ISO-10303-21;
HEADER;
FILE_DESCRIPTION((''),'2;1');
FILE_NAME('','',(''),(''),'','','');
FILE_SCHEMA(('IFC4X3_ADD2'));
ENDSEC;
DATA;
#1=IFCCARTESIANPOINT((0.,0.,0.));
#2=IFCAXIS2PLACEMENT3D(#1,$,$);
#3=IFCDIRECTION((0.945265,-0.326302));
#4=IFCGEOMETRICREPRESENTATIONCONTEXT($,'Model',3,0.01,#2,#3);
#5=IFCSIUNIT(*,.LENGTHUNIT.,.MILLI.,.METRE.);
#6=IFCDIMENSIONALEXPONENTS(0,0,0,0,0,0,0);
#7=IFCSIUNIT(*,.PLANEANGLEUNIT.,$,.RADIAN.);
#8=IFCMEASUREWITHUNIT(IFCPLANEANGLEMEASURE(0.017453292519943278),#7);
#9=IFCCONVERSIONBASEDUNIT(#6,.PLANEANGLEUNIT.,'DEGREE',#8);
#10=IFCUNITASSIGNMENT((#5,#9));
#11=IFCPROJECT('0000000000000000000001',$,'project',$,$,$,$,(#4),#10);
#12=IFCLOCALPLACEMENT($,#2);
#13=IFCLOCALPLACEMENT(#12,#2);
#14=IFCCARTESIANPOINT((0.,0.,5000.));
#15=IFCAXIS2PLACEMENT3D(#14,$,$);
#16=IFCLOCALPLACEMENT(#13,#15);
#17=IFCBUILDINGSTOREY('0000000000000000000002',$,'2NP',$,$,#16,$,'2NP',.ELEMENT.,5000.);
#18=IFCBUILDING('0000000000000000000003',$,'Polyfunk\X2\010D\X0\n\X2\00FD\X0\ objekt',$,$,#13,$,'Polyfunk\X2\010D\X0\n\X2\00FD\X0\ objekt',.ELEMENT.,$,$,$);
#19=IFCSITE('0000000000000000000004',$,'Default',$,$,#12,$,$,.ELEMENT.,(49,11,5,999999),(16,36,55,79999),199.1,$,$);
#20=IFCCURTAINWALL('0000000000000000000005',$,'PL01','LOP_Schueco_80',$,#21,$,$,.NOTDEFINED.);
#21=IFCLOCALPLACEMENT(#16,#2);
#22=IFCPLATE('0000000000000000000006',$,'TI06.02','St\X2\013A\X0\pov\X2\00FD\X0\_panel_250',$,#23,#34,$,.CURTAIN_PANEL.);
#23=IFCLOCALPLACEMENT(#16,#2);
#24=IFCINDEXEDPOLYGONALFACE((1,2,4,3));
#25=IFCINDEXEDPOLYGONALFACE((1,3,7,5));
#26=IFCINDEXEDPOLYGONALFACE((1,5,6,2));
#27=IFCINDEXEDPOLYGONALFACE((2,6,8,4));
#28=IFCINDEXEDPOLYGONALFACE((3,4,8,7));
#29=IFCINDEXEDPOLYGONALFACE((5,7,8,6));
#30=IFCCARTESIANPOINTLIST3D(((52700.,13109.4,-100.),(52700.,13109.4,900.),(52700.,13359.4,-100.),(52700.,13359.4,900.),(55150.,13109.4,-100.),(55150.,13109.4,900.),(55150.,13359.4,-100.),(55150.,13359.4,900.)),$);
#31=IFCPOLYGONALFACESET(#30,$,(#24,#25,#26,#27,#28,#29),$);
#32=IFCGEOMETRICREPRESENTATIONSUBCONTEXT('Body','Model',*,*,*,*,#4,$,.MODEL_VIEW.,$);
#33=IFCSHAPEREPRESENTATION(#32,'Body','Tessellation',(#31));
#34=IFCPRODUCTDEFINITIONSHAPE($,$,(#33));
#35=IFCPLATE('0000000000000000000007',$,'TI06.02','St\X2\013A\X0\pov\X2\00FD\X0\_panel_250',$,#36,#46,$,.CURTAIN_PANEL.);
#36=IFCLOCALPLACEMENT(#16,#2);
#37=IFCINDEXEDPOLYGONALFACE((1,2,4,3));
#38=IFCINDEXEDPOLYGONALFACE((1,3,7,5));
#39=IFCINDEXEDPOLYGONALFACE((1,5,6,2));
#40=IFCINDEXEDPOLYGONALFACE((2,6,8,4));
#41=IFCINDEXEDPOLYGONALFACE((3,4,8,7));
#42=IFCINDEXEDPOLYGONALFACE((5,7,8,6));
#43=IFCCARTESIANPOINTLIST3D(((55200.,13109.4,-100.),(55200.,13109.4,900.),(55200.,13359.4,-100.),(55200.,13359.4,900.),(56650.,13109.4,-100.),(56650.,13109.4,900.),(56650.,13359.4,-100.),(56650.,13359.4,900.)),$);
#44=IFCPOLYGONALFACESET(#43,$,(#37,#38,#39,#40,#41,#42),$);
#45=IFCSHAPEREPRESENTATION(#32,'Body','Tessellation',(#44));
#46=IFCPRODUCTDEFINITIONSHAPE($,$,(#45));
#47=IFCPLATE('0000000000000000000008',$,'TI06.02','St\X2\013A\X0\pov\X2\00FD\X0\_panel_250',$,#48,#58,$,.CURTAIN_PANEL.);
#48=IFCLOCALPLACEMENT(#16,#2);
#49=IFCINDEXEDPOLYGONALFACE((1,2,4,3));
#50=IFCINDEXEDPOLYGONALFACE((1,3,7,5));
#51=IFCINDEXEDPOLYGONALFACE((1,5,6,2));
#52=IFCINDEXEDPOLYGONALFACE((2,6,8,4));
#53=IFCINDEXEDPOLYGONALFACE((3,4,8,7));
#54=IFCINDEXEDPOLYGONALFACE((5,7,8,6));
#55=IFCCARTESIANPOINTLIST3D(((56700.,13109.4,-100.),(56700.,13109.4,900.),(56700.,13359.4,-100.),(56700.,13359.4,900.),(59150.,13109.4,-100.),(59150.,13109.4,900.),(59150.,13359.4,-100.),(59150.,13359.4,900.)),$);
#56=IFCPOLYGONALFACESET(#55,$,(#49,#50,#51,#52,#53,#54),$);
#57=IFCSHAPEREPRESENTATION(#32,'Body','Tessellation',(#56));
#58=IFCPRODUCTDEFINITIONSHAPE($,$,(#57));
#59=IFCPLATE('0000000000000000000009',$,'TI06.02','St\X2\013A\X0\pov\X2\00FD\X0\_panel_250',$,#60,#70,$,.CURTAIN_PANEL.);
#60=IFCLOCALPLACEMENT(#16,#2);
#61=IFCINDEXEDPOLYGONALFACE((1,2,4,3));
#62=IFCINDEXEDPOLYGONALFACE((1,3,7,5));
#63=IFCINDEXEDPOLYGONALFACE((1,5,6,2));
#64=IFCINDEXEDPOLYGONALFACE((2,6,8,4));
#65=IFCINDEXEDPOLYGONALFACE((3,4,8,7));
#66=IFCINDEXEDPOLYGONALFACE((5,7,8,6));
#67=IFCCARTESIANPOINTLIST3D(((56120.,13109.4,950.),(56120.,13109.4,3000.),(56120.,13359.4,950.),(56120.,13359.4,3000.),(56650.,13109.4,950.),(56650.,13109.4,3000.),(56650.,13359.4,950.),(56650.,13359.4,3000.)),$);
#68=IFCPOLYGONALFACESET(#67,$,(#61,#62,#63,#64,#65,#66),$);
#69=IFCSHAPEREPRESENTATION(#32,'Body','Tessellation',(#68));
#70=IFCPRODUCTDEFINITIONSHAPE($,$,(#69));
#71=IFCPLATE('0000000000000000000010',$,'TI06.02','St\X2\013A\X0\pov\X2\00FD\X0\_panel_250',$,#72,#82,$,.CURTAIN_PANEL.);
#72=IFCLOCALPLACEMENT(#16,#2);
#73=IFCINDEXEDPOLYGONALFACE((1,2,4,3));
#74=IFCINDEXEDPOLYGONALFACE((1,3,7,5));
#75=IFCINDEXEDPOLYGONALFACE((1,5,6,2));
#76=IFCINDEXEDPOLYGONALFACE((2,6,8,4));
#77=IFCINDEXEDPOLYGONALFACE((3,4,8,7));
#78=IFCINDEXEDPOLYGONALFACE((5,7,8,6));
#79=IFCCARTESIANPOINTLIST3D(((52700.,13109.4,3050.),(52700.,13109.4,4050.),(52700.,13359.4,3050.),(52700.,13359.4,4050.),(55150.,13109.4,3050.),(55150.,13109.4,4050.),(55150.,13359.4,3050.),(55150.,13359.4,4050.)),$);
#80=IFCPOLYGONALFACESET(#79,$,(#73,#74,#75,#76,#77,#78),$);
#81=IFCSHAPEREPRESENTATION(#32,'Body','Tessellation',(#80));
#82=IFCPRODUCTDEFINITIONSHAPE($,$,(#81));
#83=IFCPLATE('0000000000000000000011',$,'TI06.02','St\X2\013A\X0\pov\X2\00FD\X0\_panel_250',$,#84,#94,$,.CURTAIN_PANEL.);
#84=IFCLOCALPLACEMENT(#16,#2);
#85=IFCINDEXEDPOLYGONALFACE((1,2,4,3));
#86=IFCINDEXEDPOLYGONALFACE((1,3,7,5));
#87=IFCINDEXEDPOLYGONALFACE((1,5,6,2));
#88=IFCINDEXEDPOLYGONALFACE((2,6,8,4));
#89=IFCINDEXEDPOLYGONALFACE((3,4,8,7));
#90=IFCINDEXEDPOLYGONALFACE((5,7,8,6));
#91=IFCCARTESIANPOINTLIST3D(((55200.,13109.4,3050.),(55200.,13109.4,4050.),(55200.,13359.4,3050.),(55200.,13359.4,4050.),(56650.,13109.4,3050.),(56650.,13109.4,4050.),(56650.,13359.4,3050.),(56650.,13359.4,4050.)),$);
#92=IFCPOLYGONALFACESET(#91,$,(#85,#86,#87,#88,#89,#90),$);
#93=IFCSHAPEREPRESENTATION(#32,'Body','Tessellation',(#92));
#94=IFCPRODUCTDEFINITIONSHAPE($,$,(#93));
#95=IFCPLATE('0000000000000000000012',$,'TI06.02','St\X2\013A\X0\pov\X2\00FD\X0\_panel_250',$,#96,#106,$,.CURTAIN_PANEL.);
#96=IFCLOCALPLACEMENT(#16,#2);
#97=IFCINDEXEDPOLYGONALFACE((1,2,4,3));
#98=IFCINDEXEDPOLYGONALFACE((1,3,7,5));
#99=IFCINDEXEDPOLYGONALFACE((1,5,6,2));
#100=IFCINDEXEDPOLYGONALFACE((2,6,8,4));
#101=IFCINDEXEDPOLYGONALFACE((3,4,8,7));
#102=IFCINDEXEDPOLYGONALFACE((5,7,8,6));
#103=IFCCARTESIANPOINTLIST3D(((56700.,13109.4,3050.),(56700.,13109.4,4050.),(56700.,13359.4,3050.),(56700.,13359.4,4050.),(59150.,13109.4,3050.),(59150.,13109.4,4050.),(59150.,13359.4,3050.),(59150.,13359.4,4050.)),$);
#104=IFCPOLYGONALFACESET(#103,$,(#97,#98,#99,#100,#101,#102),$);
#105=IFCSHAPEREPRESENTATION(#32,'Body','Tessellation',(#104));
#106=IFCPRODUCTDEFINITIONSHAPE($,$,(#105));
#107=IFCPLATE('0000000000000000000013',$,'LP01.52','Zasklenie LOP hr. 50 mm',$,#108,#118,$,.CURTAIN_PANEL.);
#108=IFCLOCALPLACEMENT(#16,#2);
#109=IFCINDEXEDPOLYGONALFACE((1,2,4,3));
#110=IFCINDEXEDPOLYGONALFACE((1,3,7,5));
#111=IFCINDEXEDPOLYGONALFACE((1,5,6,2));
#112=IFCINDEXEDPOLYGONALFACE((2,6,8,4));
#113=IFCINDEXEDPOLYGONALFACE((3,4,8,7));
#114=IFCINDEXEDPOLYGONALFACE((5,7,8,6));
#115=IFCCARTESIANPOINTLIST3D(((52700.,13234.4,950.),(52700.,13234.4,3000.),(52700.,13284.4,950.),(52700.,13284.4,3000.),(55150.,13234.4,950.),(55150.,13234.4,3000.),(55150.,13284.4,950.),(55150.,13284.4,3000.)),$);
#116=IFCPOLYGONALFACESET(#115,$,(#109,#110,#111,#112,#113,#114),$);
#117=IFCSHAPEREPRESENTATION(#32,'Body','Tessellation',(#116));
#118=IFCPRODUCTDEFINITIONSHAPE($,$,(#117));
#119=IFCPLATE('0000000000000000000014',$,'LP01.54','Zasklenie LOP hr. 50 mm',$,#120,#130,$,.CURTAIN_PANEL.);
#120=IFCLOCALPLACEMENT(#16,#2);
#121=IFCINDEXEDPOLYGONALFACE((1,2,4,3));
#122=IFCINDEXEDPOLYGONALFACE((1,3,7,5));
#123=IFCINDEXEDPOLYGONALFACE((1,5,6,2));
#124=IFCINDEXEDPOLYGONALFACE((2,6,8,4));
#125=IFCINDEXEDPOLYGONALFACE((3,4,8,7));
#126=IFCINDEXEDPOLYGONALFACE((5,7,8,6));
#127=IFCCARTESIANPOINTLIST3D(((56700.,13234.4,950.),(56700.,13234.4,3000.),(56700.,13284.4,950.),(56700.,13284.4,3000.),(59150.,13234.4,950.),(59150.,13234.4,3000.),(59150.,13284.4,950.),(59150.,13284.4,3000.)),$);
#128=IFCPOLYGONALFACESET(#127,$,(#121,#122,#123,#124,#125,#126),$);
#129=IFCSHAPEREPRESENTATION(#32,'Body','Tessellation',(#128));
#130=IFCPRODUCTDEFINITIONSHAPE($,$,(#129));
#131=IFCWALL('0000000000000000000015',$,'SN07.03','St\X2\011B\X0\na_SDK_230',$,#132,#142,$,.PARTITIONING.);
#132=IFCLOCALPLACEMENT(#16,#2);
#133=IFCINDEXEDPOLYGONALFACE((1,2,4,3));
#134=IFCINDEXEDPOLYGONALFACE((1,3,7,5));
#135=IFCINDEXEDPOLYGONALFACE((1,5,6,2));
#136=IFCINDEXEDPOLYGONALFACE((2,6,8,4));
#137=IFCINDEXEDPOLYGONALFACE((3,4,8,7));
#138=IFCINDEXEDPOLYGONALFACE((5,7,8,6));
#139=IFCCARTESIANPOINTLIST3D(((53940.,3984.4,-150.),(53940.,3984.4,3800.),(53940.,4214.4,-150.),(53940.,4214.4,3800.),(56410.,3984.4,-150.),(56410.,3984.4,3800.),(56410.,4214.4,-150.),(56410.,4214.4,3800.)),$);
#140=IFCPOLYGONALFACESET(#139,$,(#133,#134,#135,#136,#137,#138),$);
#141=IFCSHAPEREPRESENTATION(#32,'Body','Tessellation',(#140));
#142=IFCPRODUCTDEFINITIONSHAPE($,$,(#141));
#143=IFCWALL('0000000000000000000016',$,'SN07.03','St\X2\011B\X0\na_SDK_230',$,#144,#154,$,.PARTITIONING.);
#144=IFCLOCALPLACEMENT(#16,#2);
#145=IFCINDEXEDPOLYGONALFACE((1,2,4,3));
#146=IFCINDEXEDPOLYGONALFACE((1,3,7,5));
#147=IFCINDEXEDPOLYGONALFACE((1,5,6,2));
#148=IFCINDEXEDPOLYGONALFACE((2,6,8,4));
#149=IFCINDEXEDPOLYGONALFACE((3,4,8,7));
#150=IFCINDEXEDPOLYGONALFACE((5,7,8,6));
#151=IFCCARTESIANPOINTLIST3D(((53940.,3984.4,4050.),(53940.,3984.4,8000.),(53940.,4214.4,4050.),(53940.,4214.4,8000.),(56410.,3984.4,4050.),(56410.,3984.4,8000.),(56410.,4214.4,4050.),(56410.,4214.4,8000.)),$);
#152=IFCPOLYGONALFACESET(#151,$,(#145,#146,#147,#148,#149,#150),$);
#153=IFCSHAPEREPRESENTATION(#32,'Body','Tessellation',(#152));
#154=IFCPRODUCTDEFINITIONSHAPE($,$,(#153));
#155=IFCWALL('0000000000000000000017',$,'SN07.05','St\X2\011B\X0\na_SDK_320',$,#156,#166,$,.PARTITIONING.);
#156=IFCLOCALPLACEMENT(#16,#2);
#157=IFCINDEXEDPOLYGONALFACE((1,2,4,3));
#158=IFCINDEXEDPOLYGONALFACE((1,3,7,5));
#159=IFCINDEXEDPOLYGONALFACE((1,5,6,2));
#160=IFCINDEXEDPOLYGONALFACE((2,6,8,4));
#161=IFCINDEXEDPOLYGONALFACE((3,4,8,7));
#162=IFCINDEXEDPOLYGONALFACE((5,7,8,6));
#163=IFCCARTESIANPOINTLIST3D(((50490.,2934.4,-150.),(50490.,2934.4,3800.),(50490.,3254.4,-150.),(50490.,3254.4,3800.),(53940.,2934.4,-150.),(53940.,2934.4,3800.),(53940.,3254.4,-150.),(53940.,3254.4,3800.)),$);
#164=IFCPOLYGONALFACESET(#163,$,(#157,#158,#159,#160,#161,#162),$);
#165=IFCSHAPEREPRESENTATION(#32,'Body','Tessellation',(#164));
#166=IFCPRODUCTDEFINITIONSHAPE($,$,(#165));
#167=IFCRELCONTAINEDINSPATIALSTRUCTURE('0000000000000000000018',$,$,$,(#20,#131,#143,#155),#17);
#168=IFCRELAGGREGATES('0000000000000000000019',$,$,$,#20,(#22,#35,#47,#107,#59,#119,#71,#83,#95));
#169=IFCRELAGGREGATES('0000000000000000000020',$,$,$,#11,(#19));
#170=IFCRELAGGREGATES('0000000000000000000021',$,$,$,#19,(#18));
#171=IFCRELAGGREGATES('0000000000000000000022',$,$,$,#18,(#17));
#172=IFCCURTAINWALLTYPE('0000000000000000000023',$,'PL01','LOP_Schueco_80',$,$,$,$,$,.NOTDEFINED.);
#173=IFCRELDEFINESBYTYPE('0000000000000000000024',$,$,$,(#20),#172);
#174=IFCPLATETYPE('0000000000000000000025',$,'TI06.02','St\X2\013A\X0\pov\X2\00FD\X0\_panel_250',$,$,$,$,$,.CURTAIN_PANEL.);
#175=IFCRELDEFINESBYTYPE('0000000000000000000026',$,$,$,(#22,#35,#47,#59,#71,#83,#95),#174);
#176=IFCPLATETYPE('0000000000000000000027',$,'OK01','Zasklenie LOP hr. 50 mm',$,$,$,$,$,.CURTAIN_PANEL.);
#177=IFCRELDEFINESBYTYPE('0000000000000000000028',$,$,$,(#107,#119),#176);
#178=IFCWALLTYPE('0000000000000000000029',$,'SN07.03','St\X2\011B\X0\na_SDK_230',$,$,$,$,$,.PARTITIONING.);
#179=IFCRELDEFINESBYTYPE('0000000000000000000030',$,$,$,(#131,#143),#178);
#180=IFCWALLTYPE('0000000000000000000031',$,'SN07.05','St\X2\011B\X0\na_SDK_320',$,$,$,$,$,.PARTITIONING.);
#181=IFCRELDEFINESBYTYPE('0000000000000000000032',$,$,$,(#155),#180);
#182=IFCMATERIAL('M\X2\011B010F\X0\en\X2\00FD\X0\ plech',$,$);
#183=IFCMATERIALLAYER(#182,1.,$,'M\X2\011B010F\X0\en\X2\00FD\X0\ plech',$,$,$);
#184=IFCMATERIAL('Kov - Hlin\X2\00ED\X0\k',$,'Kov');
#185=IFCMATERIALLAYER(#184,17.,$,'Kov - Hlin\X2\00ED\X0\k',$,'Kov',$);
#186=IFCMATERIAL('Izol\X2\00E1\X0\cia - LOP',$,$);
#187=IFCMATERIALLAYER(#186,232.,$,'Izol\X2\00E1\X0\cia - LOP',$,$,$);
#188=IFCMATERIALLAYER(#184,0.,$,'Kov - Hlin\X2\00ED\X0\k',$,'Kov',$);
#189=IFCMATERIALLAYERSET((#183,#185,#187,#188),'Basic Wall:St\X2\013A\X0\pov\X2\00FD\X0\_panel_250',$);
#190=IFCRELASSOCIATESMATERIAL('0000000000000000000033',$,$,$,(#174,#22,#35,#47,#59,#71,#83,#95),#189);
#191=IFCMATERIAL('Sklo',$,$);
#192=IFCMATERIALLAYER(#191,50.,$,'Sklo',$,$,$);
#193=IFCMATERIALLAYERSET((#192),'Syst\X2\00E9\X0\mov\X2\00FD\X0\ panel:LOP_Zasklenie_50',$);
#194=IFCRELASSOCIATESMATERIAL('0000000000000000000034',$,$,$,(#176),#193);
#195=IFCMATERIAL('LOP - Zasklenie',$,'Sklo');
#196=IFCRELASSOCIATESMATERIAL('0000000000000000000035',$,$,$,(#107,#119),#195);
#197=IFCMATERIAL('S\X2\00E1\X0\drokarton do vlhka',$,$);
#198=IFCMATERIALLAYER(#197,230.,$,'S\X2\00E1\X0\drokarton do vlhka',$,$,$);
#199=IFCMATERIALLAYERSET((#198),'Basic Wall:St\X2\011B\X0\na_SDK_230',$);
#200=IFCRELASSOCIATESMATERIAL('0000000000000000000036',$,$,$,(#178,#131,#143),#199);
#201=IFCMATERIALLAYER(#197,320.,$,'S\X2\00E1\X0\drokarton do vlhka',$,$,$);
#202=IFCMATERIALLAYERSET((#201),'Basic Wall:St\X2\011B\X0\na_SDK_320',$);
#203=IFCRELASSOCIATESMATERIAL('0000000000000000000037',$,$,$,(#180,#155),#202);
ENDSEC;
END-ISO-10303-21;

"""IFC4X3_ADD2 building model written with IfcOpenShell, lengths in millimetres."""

from ifc_helpers import new_model, entity, si_unit, converted_unit, direction, frame, frame_2d, origin, origin_2d_with_axis, place, context, subcontext, project, spatial, polyline, rectangle, extrude, clip, bounded_halfspace, source, transform, mapped, material, layer, layer_set, layer_usage, type_object, type_shapes, element, aggregate, save


model = new_model("IFC4X3_ADD2")

# Units and contexts
model_context = context("Model", 3, precision=0.01, world=origin(), true_north=direction((0.945265, -0.326302)))
body_context = subcontext(model_context, "Body", "Model", "MODEL_VIEW")
ifc_project = project(units=[si_unit("LENGTHUNIT", "METRE", prefix="MILLI"), converted_unit("PLANEANGLEUNIT", "DEGREE", entity("IfcPlaneAngleMeasure", 0.017453292519943278), si_unit("PLANEANGLEUNIT", "RADIAN"), dimensions=[0, 0, 0, 0, 0, 0, 0])], contexts=[model_context])

# Site, building, storey
site_placement = place(None, origin())
site = spatial("IfcSite", under=ifc_project, at=site_placement, Name="Default", CompositionType="ELEMENT", RefLatitude=(49, 11, 5, 999999), RefLongitude=(16, 36, 55, 79999), RefElevation=199.1)
building_placement = place(site_placement, origin())
building = spatial("IfcBuilding", under=site, at=building_placement, Name="Polyfunkčný objekt", LongName="Polyfunkčný objekt", CompositionType="ELEMENT")
storey_placement = place(building_placement, frame((0.0, 0.0, 5000.0)))
storey = spatial("IfcBuildingStorey", under=building, at=storey_placement, Name="2NP", LongName="2NP", CompositionType="ELEMENT", Elevation=5000.0)

# Curtain wall, plates
curtain_wall_type = type_object("IfcCurtainWallType", Name="PL01", Description="LOP_Schueco_80", PredefinedType="NOTDEFINED")
curtain_wall_placement = place(storey_placement, frame((0.0, 0.0, -5000.0)))
curtain_wall = element("IfcCurtainWall", 1, at=curtain_wall_placement, inside=storey, type_object=curtain_wall_type, Name="PL01", Description="LOP_Schueco_80", PredefinedType="NOTDEFINED")
ifc_material_1 = material(Name="Měďený plech")
ifc_layer_1 = layer(ifc_material_1, 1.0, Name="Měďený plech")
ifc_material_2 = material(Name="Kov - Hliník", Category="Kov")
ifc_layer_2 = layer(ifc_material_2, 17.0, Name="Kov - Hliník", Category="Kov")
ifc_material_3 = material(Name="Izolácia - LOP")
ifc_layer_3 = layer(ifc_material_3, 232.0, Name="Izolácia - LOP")
ifc_layer_4 = layer(ifc_material_2, 0.0, Name="Kov - Hliník", Category="Kov")
ifc_layer_set_1 = layer_set([ifc_layer_1, ifc_layer_2, ifc_layer_3, ifc_layer_4], Name="Basic Wall:Stĺpový_panel_250")
ifc_layer_usage_1 = layer_usage(ifc_layer_set_1, "AXIS2", "NEGATIVE", 125.0)
plate_type_1 = type_object("IfcPlateType", Name="TI06.02", Description="Stĺpový_panel_250", PredefinedType="CURTAIN_PANEL", material=ifc_layer_set_1)
plate_1_placement = place(storey_placement, frame((52700.0, 13234.4, -100.0)))
plate_1 = element("IfcPlate", 2, at=plate_1_placement, type_object=plate_type_1, material=ifc_layer_usage_1, Name="TI06.02", Description="Stĺpový_panel_250", PredefinedType="CURTAIN_PANEL", context=body_context, shape_type="SweptSolid", body=[
    extrude(rectangle(XDim=250.0, YDim=2450.0, at=origin_2d_with_axis()), frame((1225.0, 0.0, 0.0), z_axis=(0.0, 0.0, 1.0), x_axis=(0.0, 1.0, 0.0)), (0.0, 0.0, 1.0), 1000.0),
])
ifc_layer_usage_2 = layer_usage(ifc_layer_set_1, "AXIS2", "NEGATIVE", 125.0)
plate_2_placement = place(storey_placement, frame((55200.0, 13234.4, -100.0)))
plate_2 = element("IfcPlate", 3, at=plate_2_placement, type_object=plate_type_1, material=ifc_layer_usage_2, Name="TI06.02", Description="Stĺpový_panel_250", PredefinedType="CURTAIN_PANEL", context=body_context, shape_type="SweptSolid", body=[
    extrude(rectangle(XDim=250.0, YDim=1450.0, at=origin_2d_with_axis()), frame((725.0, 0.0, 0.0), z_axis=(0.0, 0.0, 1.0), x_axis=(0.0, 1.0, 0.0)), (0.0, 0.0, 1.0), 1000.0),
])
ifc_layer_usage_3 = layer_usage(ifc_layer_set_1, "AXIS2", "NEGATIVE", 125.0)
plate_3_placement = place(storey_placement, frame((56700.0, 13234.4, -100.0)))
plate_3 = element("IfcPlate", 4, at=plate_3_placement, type_object=plate_type_1, material=ifc_layer_usage_3, Name="TI06.02", Description="Stĺpový_panel_250", PredefinedType="CURTAIN_PANEL", context=body_context, shape_type="SweptSolid", body=[
    extrude(rectangle(XDim=250.0, YDim=2450.0, at=frame_2d((0.0, 0.0), x_axis=(1.0, 0.0))), frame((1225.0, 0.0, 0.0), z_axis=(0.0, 0.0, 1.0), x_axis=(0.0, 1.0, 0.0)), (0.0, 0.0, 1.0), 1000.0),
])
ifc_layer_usage_4 = layer_usage(ifc_layer_set_1, "AXIS2", "NEGATIVE", 125.0)
plate_4_placement = place(storey_placement, frame((56120.0, 13234.4, 950.0)))
plate_4 = element("IfcPlate", 5, at=plate_4_placement, type_object=plate_type_1, material=ifc_layer_usage_4, Name="TI06.02", Description="Stĺpový_panel_250", PredefinedType="CURTAIN_PANEL", context=body_context, shape_type="SweptSolid", body=[
    extrude(rectangle(XDim=250.0, YDim=530.0, at=frame_2d((0.0, 0.0), x_axis=(1.0, 0.0))), frame((265.0, 0.0, 0.0), z_axis=(0.0, 0.0, 1.0), x_axis=(0.0, 1.0, 0.0)), (0.0, 0.0, 1.0), 2050.0),
])
ifc_layer_usage_5 = layer_usage(ifc_layer_set_1, "AXIS2", "NEGATIVE", 125.0)
plate_5_placement = place(storey_placement, frame((52700.0, 13234.4, 3050.0)))
plate_5 = element("IfcPlate", 6, at=plate_5_placement, type_object=plate_type_1, material=ifc_layer_usage_5, Name="TI06.02", Description="Stĺpový_panel_250", PredefinedType="CURTAIN_PANEL", context=body_context, shape_type="SweptSolid", body=[
    extrude(rectangle(XDim=250.0, YDim=2450.0, at=origin_2d_with_axis()), frame((1225.0, 0.0, 0.0), z_axis=(0.0, 0.0, 1.0), x_axis=(0.0, 1.0, 0.0)), (0.0, 0.0, 1.0), 1000.0),
])
ifc_layer_usage_6 = layer_usage(ifc_layer_set_1, "AXIS2", "NEGATIVE", 125.0)
plate_6_placement = place(storey_placement, frame((55200.0, 13234.4, 3050.0)))
plate_6 = element("IfcPlate", 7, at=plate_6_placement, type_object=plate_type_1, material=ifc_layer_usage_6, Name="TI06.02", Description="Stĺpový_panel_250", PredefinedType="CURTAIN_PANEL", context=body_context, shape_type="SweptSolid", body=[
    extrude(rectangle(XDim=250.0, YDim=1450.0, at=origin_2d_with_axis()), frame((725.0, 0.0, 0.0), z_axis=(0.0, 0.0, 1.0), x_axis=(0.0, 1.0, 0.0)), (0.0, 0.0, 1.0), 1000.0),
])
ifc_layer_usage_7 = layer_usage(ifc_layer_set_1, "AXIS2", "NEGATIVE", 125.0)
plate_7_placement = place(storey_placement, frame((56700.0, 13234.4, 3050.0)))
plate_7 = element("IfcPlate", 8, at=plate_7_placement, type_object=plate_type_1, material=ifc_layer_usage_7, Name="TI06.02", Description="Stĺpový_panel_250", PredefinedType="CURTAIN_PANEL", context=body_context, shape_type="SweptSolid", body=[
    extrude(rectangle(XDim=250.0, YDim=2450.0, at=frame_2d((0.0, 0.0), x_axis=(1.0, 0.0))), frame((1225.0, 0.0, 0.0), z_axis=(0.0, 0.0, 1.0), x_axis=(0.0, 1.0, 0.0)), (0.0, 0.0, 1.0), 1000.0),
])
ifc_material_4 = material(Name="LOP - Zasklenie", Category="Sklo")
ifc_material_5 = material(Name="Sklo")
ifc_layer_5 = layer(ifc_material_5, 50.0, Name="Sklo")
ifc_layer_set_2 = layer_set([ifc_layer_5], Name="Systémový panel:LOP_Zasklenie_50")
plate_type_2 = type_object("IfcPlateType", Name="OK01", Description="Zasklenie LOP hr. 50 mm", PredefinedType="CURTAIN_PANEL", material=ifc_layer_set_2)
shared_shape_1 = source(origin(), body_context, "Body", "SweptSolid", [
    extrude(rectangle(XDim=50.0, YDim=2450.0, at=origin_2d_with_axis()), frame((0.0, 25.0, 0.0), z_axis=(0.0, 0.0, 1.0), x_axis=(0.0, 1.0, 0.0)), (0.0, 0.0, 1.0), 2050.0),
])
type_shapes(plate_type_2, [shared_shape_1])
plate_8_placement = place(curtain_wall_placement, frame((53925.0, 13234.4, 5950.0)))
plate_8 = element("IfcPlate", 9, at=plate_8_placement, type_object=plate_type_2, material=ifc_material_4, Name="LP01.52", Description="Zasklenie LOP hr. 50 mm", PredefinedType="CURTAIN_PANEL", context=body_context, shape_type="MappedRepresentation", body=[
    mapped(shared_shape_1, transform((0.0, 0.0, 0.0), scale=1.0)),
])
plate_9_placement = place(curtain_wall_placement, frame((57925.0, 13234.4, 5950.0)))
plate_9 = element("IfcPlate", 10, at=plate_9_placement, type_object=plate_type_2, material=ifc_material_4, Name="LP01.54", Description="Zasklenie LOP hr. 50 mm", PredefinedType="CURTAIN_PANEL", context=body_context, shape_type="MappedRepresentation", body=[
    mapped(shared_shape_1, transform((0.0, 0.0, 0.0), scale=1.0)),
])

# Walls
ifc_material_6 = material(Name="Sádrokarton do vlhka")
ifc_layer_6 = layer(ifc_material_6, 230.0, Name="Sádrokarton do vlhka")
ifc_layer_set_3 = layer_set([ifc_layer_6], Name="Basic Wall:Stěna_SDK_230")
wall_type_1 = type_object("IfcWallType", Name="SN07.03", Description="Stěna_SDK_230", PredefinedType="PARTITIONING", material=ifc_layer_set_3)
wall_1_placement = place(storey_placement, frame((56410.0, 4099.4, -150.0), z_axis=(0.0, 0.0, 1.0), x_axis=(-1.0, 0.0, 0.0)))
element("IfcWall", 11, at=wall_1_placement, inside=storey, type_object=wall_type_1, material=ifc_layer_set_3, Name="SN07.03", Description="Stěna_SDK_230", PredefinedType="PARTITIONING", context=body_context, shape_type="Clipping", body=[
    clip(clip(extrude(rectangle(XDim=2470.0, YDim=230.0, at=frame_2d((1235.0, 0.0), x_axis=(-1.0, 0.0))), origin(), (0.0, 0.0, 1.0), 3950.0), bounded_halfspace(frame((2470.0, -115.0, 0.0)), True, frame((2470.0, -115.0, 0.0)), polyline([(0.0, 0.0), (0.0, 60.0), (0.0, 230.0), (-320.0, 230.0), (-2470.0, 230.0), (-2470.0, 0.0), (-150.0, 0.0), (0.0, 0.0)]))), bounded_halfspace(frame((0.0, -115.0, 3950.0), z_axis=(0.0, 0.0, -1.0), x_axis=(-1.0, 0.0, 0.0)), True, frame((0.0, -115.0, 3950.0)), polyline([(0.0, 0.0), (2320.0, 0.0), (2470.0, 0.0), (2470.0, 60.0), (2470.0, 230.0), (2150.0, 230.0), (0.0, 230.0), (0.0, 0.0)]))),
])
wall_2_placement = place(storey_placement, frame((56410.0, 4099.4, 4050.0), z_axis=(0.0, 0.0, 1.0), x_axis=(-1.0, 0.0, 0.0)))
element("IfcWall", 12, at=wall_2_placement, inside=storey, type_object=wall_type_1, material=ifc_layer_set_3, Name="SN07.03", Description="Stěna_SDK_230", PredefinedType="PARTITIONING", context=body_context, shape_type="Clipping", body=[
    clip(clip(extrude(rectangle(XDim=2470.0, YDim=230.0, at=frame_2d((1235.0, 0.0), x_axis=(-1.0, 0.0))), origin(), (0.0, 0.0, 1.0), 3950.0), bounded_halfspace(frame((2470.0, -115.0, 0.0)), True, frame((2470.0, -115.0, 0.0)), polyline([(0.0, 0.0), (0.0, 60.0), (0.0, 230.0), (-320.0, 230.0), (-2470.0, 230.0), (-2470.0, 0.0), (-150.0, 0.0), (0.0, 0.0)]))), bounded_halfspace(frame((0.0, -115.0, 3950.0), z_axis=(0.0, 0.0, -1.0), x_axis=(-1.0, 0.0, 0.0)), True, frame((0.0, -115.0, 3950.0)), polyline([(0.0, 0.0), (2320.0, 0.0), (2470.0, 0.0), (2470.0, 60.0), (2470.0, 230.0), (2150.0, 230.0), (0.0, 230.0), (0.0, 0.0)]))),
])
ifc_layer_7 = layer(ifc_material_6, 320.0, Name="Sádrokarton do vlhka")
ifc_layer_set_4 = layer_set([ifc_layer_7], Name="Basic Wall:Stěna_SDK_320")
wall_type_2 = type_object("IfcWallType", Name="SN07.05", Description="Stěna_SDK_320", PredefinedType="PARTITIONING", material=ifc_layer_set_4)
wall_3_placement = place(storey_placement, frame((53940.0, 3094.4, -150.0), z_axis=(0.0, 0.0, 1.0), x_axis=(-1.0, 0.0, 0.0)))
element("IfcWall", 13, at=wall_3_placement, inside=storey, type_object=wall_type_2, material=ifc_layer_set_4, Name="SN07.05", Description="Stěna_SDK_320", PredefinedType="PARTITIONING", context=body_context, shape_type="Clipping", body=[
    clip(clip(extrude(rectangle(XDim=3450.0, YDim=320.0, at=frame_2d((1725.0, 0.0), x_axis=(-1.0, 0.0))), origin(), (0.0, 0.0, 1.0), 3950.0), bounded_halfspace(frame((3450.0, -160.0, 0.0)), True, frame((3450.0, -160.0, 0.0)), polyline([(0.0, 0.0), (0.0, 320.0), (-1650.0, 320.0), (-1800.0, 320.0), (-3450.0, 320.0), (-3450.0, 0.0), (-1800.0, 0.0), (-1650.0, 0.0), (0.0, 0.0)]))), bounded_halfspace(frame((0.0, -160.0, 3950.0), z_axis=(0.0, 0.0, -1.0), x_axis=(-1.0, 0.0, 0.0)), True, frame((0.0, -160.0, 3950.0)), polyline([(0.0, 0.0), (1650.0, 0.0), (1800.0, 0.0), (3450.0, 0.0), (3450.0, 320.0), (1800.0, 320.0), (1650.0, 320.0), (0.0, 320.0), (0.0, 0.0)]))),
])

aggregate(curtain_wall, [plate_1, plate_2, plate_3, plate_8, plate_4, plate_9, plate_5, plate_6, plate_7])

save(model, "model.ifc")
